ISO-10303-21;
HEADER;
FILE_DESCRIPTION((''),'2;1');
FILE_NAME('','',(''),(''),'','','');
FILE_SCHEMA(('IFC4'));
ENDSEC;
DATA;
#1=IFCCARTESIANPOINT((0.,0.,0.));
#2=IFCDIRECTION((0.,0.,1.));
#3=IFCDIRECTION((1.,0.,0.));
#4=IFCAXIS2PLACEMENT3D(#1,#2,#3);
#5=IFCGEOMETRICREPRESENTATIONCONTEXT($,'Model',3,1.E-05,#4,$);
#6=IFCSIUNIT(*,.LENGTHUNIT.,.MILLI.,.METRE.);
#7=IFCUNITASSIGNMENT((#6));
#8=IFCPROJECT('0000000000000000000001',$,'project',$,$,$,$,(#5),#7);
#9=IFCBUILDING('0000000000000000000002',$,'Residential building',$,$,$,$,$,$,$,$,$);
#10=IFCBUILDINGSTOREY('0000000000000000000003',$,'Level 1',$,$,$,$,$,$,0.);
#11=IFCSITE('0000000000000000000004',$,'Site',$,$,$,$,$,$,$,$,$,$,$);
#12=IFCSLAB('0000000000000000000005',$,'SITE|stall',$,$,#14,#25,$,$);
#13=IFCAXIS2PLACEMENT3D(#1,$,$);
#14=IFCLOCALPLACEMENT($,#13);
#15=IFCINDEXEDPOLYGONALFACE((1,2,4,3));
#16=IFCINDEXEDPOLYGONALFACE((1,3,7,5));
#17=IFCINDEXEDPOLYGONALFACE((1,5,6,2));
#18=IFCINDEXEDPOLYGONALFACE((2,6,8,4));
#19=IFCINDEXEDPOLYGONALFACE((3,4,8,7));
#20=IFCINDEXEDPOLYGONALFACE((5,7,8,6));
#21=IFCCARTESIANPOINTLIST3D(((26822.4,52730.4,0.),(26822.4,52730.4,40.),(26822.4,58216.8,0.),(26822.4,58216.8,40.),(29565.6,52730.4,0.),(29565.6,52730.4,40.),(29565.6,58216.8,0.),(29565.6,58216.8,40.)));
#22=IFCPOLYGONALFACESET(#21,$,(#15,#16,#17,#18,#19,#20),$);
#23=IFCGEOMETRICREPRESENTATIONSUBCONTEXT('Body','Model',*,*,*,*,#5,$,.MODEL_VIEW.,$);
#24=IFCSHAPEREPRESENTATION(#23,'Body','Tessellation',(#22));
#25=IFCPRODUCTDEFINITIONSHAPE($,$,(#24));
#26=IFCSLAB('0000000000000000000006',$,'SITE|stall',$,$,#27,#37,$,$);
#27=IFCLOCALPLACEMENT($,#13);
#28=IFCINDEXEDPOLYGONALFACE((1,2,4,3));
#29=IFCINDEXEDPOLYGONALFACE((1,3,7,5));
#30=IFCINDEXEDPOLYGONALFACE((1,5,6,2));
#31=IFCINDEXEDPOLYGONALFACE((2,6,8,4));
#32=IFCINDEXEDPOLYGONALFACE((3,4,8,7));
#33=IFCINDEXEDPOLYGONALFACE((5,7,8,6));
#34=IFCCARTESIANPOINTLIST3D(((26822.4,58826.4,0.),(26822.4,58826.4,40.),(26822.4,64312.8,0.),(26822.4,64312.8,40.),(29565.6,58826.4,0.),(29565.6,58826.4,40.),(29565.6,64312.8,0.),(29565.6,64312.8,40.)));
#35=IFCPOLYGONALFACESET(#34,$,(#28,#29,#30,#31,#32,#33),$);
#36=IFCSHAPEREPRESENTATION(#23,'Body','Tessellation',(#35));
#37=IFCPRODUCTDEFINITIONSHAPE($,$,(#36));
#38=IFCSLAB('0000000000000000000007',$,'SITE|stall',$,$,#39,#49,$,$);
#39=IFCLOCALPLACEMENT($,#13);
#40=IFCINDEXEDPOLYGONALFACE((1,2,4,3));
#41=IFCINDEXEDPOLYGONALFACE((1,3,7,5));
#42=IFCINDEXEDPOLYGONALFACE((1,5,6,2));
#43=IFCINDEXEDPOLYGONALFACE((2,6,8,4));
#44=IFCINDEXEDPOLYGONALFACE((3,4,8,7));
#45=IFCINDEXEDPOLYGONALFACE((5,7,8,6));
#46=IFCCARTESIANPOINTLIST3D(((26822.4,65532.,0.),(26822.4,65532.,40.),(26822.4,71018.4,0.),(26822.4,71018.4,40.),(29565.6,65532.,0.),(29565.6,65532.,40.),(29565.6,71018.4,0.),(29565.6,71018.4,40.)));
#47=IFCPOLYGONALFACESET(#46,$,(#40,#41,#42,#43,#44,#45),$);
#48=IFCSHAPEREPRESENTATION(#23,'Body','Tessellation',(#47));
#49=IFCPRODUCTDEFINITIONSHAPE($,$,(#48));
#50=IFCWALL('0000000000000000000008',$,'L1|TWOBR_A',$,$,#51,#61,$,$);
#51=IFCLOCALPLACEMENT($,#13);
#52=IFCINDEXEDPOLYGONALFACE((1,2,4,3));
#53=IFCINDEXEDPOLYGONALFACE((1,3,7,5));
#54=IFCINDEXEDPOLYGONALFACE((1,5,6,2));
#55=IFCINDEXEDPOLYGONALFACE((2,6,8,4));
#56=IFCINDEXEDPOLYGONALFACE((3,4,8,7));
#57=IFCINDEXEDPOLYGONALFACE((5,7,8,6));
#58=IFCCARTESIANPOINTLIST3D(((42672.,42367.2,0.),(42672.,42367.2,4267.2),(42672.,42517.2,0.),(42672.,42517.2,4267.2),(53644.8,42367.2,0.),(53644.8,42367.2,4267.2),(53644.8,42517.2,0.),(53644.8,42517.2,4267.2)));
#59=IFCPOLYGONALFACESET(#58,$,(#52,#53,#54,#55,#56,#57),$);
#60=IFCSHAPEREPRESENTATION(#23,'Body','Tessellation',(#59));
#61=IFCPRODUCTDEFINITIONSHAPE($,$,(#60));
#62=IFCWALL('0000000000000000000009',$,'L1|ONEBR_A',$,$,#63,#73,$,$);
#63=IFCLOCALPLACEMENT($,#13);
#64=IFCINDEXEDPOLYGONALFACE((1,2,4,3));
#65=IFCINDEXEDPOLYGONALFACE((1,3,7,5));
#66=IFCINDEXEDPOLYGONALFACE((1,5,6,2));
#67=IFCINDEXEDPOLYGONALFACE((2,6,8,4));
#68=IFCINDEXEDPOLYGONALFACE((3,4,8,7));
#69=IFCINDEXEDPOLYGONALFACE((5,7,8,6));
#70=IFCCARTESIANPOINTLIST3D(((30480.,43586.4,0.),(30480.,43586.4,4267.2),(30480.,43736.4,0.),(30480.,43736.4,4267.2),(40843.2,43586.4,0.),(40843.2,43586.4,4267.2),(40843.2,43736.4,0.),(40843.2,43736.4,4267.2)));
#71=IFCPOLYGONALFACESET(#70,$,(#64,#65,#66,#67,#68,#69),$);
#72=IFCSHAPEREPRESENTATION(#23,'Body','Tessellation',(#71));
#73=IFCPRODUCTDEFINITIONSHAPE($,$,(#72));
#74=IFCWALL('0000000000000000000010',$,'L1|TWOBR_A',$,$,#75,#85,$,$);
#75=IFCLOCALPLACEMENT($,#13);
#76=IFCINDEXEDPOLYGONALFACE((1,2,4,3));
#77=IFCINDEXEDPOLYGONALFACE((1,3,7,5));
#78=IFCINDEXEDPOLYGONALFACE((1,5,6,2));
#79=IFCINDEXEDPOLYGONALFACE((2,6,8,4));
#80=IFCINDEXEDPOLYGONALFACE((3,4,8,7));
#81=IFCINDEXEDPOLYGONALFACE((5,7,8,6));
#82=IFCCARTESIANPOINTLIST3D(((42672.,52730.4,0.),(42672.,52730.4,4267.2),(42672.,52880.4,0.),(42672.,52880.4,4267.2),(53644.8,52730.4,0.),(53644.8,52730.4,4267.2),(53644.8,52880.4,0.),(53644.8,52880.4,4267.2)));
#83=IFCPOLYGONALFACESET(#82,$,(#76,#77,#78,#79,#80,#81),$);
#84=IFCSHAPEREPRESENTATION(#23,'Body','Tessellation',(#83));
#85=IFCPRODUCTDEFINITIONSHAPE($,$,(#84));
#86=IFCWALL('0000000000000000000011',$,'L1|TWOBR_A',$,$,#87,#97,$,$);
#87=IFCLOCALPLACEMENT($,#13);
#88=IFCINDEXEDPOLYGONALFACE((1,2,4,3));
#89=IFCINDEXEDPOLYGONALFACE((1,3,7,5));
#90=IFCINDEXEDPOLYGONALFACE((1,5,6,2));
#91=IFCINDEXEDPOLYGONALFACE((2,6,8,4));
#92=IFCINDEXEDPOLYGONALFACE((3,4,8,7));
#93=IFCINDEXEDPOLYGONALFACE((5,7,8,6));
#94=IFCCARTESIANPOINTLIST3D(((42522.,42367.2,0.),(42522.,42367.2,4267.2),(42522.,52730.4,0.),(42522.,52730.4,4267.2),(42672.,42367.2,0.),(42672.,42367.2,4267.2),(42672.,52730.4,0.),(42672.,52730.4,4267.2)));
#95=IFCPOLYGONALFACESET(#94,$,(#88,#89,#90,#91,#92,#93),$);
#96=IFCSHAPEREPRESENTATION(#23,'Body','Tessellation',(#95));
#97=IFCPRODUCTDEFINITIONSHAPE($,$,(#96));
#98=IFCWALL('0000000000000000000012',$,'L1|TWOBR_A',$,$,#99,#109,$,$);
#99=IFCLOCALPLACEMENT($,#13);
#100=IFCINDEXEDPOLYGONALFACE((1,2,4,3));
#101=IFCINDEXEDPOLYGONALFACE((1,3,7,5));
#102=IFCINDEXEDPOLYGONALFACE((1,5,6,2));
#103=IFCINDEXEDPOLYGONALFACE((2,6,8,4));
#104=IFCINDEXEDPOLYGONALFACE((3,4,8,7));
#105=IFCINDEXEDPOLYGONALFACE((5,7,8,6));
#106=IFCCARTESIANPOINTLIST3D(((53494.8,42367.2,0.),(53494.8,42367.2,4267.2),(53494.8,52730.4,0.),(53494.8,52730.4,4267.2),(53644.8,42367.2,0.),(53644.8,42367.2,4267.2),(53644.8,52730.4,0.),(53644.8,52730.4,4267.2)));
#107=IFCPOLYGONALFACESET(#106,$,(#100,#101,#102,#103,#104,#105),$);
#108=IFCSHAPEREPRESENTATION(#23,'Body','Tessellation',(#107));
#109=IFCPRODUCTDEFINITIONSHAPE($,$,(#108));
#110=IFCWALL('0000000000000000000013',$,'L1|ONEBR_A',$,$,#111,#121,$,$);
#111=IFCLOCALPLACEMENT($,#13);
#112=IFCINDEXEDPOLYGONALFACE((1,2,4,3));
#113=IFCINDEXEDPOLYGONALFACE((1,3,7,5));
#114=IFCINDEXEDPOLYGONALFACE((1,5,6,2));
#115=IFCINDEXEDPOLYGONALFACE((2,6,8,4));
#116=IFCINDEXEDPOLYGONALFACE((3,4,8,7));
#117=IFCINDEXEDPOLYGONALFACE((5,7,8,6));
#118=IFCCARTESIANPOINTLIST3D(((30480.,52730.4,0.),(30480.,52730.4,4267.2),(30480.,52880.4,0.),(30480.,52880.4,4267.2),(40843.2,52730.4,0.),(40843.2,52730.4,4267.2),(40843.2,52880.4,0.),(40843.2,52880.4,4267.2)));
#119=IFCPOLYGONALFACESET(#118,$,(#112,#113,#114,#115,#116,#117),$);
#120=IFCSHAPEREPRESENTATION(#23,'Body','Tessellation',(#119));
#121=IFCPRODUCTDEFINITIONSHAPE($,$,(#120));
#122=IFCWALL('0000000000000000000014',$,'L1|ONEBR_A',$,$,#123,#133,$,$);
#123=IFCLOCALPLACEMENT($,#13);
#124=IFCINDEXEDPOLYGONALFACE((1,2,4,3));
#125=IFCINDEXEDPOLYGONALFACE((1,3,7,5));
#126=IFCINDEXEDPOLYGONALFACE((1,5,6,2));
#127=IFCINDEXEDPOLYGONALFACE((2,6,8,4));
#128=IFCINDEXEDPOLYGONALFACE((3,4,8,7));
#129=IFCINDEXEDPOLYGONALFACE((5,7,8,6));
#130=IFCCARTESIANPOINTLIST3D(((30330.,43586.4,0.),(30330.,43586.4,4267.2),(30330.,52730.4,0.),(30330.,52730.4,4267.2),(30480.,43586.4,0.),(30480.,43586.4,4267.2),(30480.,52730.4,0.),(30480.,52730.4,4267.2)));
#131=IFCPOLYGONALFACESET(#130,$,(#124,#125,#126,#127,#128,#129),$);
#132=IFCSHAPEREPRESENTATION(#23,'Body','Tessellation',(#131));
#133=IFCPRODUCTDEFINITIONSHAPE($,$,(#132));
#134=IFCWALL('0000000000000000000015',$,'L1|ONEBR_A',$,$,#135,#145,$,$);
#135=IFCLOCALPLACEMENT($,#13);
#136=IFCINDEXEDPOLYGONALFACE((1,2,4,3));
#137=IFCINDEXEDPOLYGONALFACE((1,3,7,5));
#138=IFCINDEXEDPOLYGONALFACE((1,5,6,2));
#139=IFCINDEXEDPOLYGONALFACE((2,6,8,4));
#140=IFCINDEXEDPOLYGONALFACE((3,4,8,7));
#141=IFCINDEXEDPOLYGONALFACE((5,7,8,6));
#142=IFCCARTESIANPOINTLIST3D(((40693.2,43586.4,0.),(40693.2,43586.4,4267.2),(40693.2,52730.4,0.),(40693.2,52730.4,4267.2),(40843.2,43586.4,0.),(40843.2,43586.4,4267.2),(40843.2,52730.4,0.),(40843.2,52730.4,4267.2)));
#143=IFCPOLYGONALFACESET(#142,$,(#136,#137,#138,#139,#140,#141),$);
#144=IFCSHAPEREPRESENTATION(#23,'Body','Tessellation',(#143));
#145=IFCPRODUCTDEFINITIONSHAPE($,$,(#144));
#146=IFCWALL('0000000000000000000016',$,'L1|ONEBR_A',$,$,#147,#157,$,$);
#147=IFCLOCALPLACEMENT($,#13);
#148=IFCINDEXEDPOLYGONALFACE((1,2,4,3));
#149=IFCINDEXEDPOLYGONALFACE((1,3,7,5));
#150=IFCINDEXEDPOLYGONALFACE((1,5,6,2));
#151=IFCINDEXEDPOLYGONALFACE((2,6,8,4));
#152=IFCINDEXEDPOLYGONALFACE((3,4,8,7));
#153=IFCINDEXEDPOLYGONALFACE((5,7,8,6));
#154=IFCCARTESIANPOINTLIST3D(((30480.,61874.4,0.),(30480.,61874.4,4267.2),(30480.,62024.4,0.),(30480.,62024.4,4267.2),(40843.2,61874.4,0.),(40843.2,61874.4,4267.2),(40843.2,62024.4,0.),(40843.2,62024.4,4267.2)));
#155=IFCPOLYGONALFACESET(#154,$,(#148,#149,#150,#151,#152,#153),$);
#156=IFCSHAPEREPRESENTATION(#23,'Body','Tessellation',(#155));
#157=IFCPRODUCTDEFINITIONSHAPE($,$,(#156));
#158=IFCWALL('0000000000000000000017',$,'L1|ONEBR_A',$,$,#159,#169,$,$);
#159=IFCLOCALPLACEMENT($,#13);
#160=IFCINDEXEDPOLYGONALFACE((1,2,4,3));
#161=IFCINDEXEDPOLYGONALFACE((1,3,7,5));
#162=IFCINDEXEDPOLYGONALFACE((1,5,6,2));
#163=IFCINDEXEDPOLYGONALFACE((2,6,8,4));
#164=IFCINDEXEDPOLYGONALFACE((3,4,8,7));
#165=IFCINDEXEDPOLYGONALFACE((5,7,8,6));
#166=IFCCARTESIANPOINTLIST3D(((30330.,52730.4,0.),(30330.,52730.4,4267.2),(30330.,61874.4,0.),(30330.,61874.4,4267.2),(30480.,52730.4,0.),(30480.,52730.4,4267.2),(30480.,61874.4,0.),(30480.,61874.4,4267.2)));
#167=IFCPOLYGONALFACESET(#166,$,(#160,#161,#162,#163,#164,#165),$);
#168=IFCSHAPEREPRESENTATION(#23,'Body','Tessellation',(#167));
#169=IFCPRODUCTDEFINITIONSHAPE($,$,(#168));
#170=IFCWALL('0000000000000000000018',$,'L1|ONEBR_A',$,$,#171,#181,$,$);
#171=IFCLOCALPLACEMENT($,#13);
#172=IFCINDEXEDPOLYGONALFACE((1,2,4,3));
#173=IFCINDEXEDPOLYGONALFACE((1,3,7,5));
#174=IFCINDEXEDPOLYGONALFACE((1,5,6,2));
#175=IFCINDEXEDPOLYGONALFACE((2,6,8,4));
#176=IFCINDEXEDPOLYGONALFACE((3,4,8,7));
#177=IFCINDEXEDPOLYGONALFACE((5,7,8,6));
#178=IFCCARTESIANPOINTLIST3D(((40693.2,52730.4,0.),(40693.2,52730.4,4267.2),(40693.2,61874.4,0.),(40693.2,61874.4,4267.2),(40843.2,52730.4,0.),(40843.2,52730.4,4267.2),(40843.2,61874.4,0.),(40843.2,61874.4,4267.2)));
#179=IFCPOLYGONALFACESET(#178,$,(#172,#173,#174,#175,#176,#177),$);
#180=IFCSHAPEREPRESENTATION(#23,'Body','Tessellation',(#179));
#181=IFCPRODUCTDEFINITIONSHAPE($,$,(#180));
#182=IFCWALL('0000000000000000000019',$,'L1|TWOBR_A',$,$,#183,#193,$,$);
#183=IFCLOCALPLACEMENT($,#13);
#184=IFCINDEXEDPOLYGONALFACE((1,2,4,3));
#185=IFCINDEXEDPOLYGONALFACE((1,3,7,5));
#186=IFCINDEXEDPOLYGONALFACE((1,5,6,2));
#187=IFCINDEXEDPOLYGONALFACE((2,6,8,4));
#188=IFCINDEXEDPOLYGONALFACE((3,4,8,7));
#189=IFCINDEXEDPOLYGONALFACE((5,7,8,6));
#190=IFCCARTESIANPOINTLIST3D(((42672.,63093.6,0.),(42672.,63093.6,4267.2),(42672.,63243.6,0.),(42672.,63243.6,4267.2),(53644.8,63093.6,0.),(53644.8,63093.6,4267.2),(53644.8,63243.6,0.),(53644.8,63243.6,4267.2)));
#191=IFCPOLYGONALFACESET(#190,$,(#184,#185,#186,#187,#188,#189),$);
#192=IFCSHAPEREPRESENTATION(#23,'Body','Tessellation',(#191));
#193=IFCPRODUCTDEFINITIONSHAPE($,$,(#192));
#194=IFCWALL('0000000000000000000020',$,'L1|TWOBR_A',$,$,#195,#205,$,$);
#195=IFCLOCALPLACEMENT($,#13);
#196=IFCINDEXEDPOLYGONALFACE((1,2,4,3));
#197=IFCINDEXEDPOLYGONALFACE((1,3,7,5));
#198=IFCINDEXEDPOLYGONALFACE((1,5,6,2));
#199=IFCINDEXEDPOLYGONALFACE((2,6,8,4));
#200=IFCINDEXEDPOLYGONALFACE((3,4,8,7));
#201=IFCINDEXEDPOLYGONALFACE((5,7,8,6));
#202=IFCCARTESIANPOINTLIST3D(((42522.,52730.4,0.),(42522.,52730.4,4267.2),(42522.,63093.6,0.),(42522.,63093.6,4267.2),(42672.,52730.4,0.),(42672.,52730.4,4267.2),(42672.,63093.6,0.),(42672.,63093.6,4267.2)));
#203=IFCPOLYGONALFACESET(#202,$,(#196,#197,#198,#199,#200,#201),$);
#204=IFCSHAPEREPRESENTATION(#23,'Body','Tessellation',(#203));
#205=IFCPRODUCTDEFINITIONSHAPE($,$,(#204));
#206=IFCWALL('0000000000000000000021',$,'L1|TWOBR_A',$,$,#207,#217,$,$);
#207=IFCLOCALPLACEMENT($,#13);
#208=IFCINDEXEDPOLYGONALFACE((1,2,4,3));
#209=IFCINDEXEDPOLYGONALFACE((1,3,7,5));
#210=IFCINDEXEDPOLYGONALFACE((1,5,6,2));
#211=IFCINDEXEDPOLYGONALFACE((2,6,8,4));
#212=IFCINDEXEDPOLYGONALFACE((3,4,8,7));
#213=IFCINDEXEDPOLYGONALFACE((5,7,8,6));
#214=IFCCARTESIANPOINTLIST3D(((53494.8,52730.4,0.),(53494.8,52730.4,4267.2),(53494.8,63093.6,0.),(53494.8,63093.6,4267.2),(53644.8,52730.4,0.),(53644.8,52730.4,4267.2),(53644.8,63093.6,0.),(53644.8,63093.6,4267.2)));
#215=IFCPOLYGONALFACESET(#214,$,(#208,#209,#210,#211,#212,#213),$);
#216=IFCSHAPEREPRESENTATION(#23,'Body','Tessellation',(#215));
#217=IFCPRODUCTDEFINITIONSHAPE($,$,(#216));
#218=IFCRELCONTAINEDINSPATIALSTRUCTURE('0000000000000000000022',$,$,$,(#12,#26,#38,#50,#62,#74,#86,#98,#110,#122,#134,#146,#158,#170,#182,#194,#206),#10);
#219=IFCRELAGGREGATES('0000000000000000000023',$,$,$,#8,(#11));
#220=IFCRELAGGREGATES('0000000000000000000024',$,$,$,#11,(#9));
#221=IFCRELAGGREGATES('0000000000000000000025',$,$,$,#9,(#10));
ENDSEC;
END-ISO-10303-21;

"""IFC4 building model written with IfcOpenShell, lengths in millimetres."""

from ifc_helpers import new_model, si_unit, frame, origin_with_axes, place, context, subcontext, project, spatial, indexed_curve, outline, extrude, element, save


model = new_model("IFC4")

# Units and contexts
model_context = context("Model", 3, precision=1e-05, world=origin_with_axes())
body_context = subcontext(model_context, "Body", "Model", "MODEL_VIEW")
ifc_project = project(units=[si_unit("LENGTHUNIT", "METRE", prefix="MILLI")], contexts=[model_context])

# Site, building, storey
site = spatial("IfcSite", under=ifc_project, Name="Site")
building = spatial("IfcBuilding", under=site, Name="Residential building")
storey = spatial("IfcBuildingStorey", under=building, Name="Level 1", Elevation=0.0)

# Slabs
for number, where, z_axis, x_axis, name in (
    (1, (26822.4, 52730.4, 0.0), (0.0, 0.0, 1.0), (1.0, 0.0, 0.0), "SITE|stall"),
    (2, (26822.4, 58826.4, 0.0), (0.0, 0.0, 1.0), (1.0, 0.0, 0.0), "SITE|stall"),
    (3, (26822.4, 65532.0, 0.0), (0.0, 0.0, 1.0), (1.0, 0.0, 0.0), "SITE|stall"),
):
    element("IfcSlab", number, at=place(None, frame(where, z_axis=z_axis, x_axis=x_axis)), inside=storey, Name=name, context=body_context, shape_type="SweptSolid", body=[
        extrude(outline(indexed_curve([(0.0, 0.0), (2743.2, 0.0), (2743.2, 5486.4), (0.0, 5486.4), (0.0, 0.0)])), None, (0.0, 0.0, 1.0), 40.0),
    ])

# Walls
wall_1_placement = place(None, frame((42672.0, 42367.2, 0.0), z_axis=(0.0, 0.0, 1.0), x_axis=(1.0, 0.0, 0.0)))
element("IfcWall", 4, at=wall_1_placement, inside=storey, Name="L1|TWOBR_A", context=body_context, shape_type="SweptSolid", body=[
    extrude(outline(indexed_curve([(0.0, 0.0), (0.0, 150.0), (10972.8, 150.0), (10972.8, 0.0), (0.0, 0.0)], self_intersect=False)), origin_with_axes(), (0.0, 0.0, 1.0), 4267.2),
])
wall_2_placement = place(None, frame((30480.0, 43586.4, 0.0), z_axis=(0.0, 0.0, 1.0), x_axis=(1.0, 0.0, 0.0)))
element("IfcWall", 5, at=wall_2_placement, inside=storey, Name="L1|ONEBR_A", context=body_context, shape_type="SweptSolid", body=[
    extrude(outline(indexed_curve([(0.0, 0.0), (0.0, 150.0), (10363.2, 150.0), (10363.2, 0.0), (0.0, 0.0)], self_intersect=False)), origin_with_axes(), (0.0, 0.0, 1.0), 4267.2),
])
for number, where, z_axis, x_axis, name in (
    (6, (42672.0, 52730.4, 0.0), (0.0, 0.0, 1.0), (1.0, 0.0, 0.0), "L1|TWOBR_A"),
):
    element("IfcWall", number, at=place(None, frame(where, z_axis=z_axis, x_axis=x_axis)), inside=storey, Name=name, context=body_context, shape_type="SweptSolid", body=[
        extrude(outline(indexed_curve([(0.0, 0.0), (0.0, 150.0), (10972.8, 150.0), (10972.8, 0.0), (0.0, 0.0)], self_intersect=False)), origin_with_axes(), (0.0, 0.0, 1.0), 4267.2),
    ])
for number, where, z_axis, x_axis, name in (
    (7, (42672.0, 42367.2, 0.0), (0.0, 0.0, 1.0), (0.0, 1.0, 0.0), "L1|TWOBR_A"),
    (8, (53644.8, 42367.2, 0.0), (0.0, 0.0, 1.0), (0.0, 1.0, 0.0), "L1|TWOBR_A"),
    (9, (30480.0, 52730.4, 0.0), (0.0, 0.0, 1.0), (1.0, 0.0, 0.0), "L1|ONEBR_A"),
):
    element("IfcWall", number, at=place(None, frame(where, z_axis=z_axis, x_axis=x_axis)), inside=storey, Name=name, context=body_context, shape_type="SweptSolid", body=[
        extrude(outline(indexed_curve([(0.0, 0.0), (0.0, 150.0), (10363.2, 150.0), (10363.2, 0.0), (0.0, 0.0)], self_intersect=False)), origin_with_axes(), (0.0, 0.0, 1.0), 4267.2),
    ])
for number, where, z_axis, x_axis, name in (
    (10, (30480.0, 43586.4, 0.0), (0.0, 0.0, 1.0), (0.0, 1.0, 0.0), "L1|ONEBR_A"),
    (11, (40843.2, 43586.4, 0.0), (0.0, 0.0, 1.0), (0.0, 1.0, 0.0), "L1|ONEBR_A"),
):
    element("IfcWall", number, at=place(None, frame(where, z_axis=z_axis, x_axis=x_axis)), inside=storey, Name=name, context=body_context, shape_type="SweptSolid", body=[
        extrude(outline(indexed_curve([(0.0, 0.0), (0.0, 150.0), (9144.0, 150.0), (9144.0, 0.0), (0.0, 0.0)], self_intersect=False)), origin_with_axes(), (0.0, 0.0, 1.0), 4267.2),
    ])
for number, where, z_axis, x_axis, name in (
    (12, (30480.0, 61874.4, 0.0), (0.0, 0.0, 1.0), (1.0, 0.0, 0.0), "L1|ONEBR_A"),
):
    element("IfcWall", number, at=place(None, frame(where, z_axis=z_axis, x_axis=x_axis)), inside=storey, Name=name, context=body_context, shape_type="SweptSolid", body=[
        extrude(outline(indexed_curve([(0.0, 0.0), (0.0, 150.0), (10363.2, 150.0), (10363.2, 0.0), (0.0, 0.0)], self_intersect=False)), origin_with_axes(), (0.0, 0.0, 1.0), 4267.2),
    ])
for number, where, z_axis, x_axis, name in (
    (13, (30480.0, 52730.4, 0.0), (0.0, 0.0, 1.0), (0.0, 1.0, 0.0), "L1|ONEBR_A"),
    (14, (40843.2, 52730.4, 0.0), (0.0, 0.0, 1.0), (0.0, 1.0, 0.0), "L1|ONEBR_A"),
):
    element("IfcWall", number, at=place(None, frame(where, z_axis=z_axis, x_axis=x_axis)), inside=storey, Name=name, context=body_context, shape_type="SweptSolid", body=[
        extrude(outline(indexed_curve([(0.0, 0.0), (0.0, 150.0), (9144.0, 150.0), (9144.0, 0.0), (0.0, 0.0)], self_intersect=False)), origin_with_axes(), (0.0, 0.0, 1.0), 4267.2),
    ])
for number, where, z_axis, x_axis, name in (
    (15, (42672.0, 63093.6, 0.0), (0.0, 0.0, 1.0), (1.0, 0.0, 0.0), "L1|TWOBR_A"),
):
    element("IfcWall", number, at=place(None, frame(where, z_axis=z_axis, x_axis=x_axis)), inside=storey, Name=name, context=body_context, shape_type="SweptSolid", body=[
        extrude(outline(indexed_curve([(0.0, 0.0), (0.0, 150.0), (10972.8, 150.0), (10972.8, 0.0), (0.0, 0.0)], self_intersect=False)), origin_with_axes(), (0.0, 0.0, 1.0), 4267.2),
    ])
for number, where, z_axis, x_axis, name in (
    (16, (42672.0, 52730.4, 0.0), (0.0, 0.0, 1.0), (0.0, 1.0, 0.0), "L1|TWOBR_A"),
    (17, (53644.8, 52730.4, 0.0), (0.0, 0.0, 1.0), (0.0, 1.0, 0.0), "L1|TWOBR_A"),
):
    element("IfcWall", number, at=place(None, frame(where, z_axis=z_axis, x_axis=x_axis)), inside=storey, Name=name, context=body_context, shape_type="SweptSolid", body=[
        extrude(outline(indexed_curve([(0.0, 0.0), (0.0, 150.0), (10363.2, 150.0), (10363.2, 0.0), (0.0, 0.0)], self_intersect=False)), origin_with_axes(), (0.0, 0.0, 1.0), 4267.2),
    ])

save(model, "model.ifc")
